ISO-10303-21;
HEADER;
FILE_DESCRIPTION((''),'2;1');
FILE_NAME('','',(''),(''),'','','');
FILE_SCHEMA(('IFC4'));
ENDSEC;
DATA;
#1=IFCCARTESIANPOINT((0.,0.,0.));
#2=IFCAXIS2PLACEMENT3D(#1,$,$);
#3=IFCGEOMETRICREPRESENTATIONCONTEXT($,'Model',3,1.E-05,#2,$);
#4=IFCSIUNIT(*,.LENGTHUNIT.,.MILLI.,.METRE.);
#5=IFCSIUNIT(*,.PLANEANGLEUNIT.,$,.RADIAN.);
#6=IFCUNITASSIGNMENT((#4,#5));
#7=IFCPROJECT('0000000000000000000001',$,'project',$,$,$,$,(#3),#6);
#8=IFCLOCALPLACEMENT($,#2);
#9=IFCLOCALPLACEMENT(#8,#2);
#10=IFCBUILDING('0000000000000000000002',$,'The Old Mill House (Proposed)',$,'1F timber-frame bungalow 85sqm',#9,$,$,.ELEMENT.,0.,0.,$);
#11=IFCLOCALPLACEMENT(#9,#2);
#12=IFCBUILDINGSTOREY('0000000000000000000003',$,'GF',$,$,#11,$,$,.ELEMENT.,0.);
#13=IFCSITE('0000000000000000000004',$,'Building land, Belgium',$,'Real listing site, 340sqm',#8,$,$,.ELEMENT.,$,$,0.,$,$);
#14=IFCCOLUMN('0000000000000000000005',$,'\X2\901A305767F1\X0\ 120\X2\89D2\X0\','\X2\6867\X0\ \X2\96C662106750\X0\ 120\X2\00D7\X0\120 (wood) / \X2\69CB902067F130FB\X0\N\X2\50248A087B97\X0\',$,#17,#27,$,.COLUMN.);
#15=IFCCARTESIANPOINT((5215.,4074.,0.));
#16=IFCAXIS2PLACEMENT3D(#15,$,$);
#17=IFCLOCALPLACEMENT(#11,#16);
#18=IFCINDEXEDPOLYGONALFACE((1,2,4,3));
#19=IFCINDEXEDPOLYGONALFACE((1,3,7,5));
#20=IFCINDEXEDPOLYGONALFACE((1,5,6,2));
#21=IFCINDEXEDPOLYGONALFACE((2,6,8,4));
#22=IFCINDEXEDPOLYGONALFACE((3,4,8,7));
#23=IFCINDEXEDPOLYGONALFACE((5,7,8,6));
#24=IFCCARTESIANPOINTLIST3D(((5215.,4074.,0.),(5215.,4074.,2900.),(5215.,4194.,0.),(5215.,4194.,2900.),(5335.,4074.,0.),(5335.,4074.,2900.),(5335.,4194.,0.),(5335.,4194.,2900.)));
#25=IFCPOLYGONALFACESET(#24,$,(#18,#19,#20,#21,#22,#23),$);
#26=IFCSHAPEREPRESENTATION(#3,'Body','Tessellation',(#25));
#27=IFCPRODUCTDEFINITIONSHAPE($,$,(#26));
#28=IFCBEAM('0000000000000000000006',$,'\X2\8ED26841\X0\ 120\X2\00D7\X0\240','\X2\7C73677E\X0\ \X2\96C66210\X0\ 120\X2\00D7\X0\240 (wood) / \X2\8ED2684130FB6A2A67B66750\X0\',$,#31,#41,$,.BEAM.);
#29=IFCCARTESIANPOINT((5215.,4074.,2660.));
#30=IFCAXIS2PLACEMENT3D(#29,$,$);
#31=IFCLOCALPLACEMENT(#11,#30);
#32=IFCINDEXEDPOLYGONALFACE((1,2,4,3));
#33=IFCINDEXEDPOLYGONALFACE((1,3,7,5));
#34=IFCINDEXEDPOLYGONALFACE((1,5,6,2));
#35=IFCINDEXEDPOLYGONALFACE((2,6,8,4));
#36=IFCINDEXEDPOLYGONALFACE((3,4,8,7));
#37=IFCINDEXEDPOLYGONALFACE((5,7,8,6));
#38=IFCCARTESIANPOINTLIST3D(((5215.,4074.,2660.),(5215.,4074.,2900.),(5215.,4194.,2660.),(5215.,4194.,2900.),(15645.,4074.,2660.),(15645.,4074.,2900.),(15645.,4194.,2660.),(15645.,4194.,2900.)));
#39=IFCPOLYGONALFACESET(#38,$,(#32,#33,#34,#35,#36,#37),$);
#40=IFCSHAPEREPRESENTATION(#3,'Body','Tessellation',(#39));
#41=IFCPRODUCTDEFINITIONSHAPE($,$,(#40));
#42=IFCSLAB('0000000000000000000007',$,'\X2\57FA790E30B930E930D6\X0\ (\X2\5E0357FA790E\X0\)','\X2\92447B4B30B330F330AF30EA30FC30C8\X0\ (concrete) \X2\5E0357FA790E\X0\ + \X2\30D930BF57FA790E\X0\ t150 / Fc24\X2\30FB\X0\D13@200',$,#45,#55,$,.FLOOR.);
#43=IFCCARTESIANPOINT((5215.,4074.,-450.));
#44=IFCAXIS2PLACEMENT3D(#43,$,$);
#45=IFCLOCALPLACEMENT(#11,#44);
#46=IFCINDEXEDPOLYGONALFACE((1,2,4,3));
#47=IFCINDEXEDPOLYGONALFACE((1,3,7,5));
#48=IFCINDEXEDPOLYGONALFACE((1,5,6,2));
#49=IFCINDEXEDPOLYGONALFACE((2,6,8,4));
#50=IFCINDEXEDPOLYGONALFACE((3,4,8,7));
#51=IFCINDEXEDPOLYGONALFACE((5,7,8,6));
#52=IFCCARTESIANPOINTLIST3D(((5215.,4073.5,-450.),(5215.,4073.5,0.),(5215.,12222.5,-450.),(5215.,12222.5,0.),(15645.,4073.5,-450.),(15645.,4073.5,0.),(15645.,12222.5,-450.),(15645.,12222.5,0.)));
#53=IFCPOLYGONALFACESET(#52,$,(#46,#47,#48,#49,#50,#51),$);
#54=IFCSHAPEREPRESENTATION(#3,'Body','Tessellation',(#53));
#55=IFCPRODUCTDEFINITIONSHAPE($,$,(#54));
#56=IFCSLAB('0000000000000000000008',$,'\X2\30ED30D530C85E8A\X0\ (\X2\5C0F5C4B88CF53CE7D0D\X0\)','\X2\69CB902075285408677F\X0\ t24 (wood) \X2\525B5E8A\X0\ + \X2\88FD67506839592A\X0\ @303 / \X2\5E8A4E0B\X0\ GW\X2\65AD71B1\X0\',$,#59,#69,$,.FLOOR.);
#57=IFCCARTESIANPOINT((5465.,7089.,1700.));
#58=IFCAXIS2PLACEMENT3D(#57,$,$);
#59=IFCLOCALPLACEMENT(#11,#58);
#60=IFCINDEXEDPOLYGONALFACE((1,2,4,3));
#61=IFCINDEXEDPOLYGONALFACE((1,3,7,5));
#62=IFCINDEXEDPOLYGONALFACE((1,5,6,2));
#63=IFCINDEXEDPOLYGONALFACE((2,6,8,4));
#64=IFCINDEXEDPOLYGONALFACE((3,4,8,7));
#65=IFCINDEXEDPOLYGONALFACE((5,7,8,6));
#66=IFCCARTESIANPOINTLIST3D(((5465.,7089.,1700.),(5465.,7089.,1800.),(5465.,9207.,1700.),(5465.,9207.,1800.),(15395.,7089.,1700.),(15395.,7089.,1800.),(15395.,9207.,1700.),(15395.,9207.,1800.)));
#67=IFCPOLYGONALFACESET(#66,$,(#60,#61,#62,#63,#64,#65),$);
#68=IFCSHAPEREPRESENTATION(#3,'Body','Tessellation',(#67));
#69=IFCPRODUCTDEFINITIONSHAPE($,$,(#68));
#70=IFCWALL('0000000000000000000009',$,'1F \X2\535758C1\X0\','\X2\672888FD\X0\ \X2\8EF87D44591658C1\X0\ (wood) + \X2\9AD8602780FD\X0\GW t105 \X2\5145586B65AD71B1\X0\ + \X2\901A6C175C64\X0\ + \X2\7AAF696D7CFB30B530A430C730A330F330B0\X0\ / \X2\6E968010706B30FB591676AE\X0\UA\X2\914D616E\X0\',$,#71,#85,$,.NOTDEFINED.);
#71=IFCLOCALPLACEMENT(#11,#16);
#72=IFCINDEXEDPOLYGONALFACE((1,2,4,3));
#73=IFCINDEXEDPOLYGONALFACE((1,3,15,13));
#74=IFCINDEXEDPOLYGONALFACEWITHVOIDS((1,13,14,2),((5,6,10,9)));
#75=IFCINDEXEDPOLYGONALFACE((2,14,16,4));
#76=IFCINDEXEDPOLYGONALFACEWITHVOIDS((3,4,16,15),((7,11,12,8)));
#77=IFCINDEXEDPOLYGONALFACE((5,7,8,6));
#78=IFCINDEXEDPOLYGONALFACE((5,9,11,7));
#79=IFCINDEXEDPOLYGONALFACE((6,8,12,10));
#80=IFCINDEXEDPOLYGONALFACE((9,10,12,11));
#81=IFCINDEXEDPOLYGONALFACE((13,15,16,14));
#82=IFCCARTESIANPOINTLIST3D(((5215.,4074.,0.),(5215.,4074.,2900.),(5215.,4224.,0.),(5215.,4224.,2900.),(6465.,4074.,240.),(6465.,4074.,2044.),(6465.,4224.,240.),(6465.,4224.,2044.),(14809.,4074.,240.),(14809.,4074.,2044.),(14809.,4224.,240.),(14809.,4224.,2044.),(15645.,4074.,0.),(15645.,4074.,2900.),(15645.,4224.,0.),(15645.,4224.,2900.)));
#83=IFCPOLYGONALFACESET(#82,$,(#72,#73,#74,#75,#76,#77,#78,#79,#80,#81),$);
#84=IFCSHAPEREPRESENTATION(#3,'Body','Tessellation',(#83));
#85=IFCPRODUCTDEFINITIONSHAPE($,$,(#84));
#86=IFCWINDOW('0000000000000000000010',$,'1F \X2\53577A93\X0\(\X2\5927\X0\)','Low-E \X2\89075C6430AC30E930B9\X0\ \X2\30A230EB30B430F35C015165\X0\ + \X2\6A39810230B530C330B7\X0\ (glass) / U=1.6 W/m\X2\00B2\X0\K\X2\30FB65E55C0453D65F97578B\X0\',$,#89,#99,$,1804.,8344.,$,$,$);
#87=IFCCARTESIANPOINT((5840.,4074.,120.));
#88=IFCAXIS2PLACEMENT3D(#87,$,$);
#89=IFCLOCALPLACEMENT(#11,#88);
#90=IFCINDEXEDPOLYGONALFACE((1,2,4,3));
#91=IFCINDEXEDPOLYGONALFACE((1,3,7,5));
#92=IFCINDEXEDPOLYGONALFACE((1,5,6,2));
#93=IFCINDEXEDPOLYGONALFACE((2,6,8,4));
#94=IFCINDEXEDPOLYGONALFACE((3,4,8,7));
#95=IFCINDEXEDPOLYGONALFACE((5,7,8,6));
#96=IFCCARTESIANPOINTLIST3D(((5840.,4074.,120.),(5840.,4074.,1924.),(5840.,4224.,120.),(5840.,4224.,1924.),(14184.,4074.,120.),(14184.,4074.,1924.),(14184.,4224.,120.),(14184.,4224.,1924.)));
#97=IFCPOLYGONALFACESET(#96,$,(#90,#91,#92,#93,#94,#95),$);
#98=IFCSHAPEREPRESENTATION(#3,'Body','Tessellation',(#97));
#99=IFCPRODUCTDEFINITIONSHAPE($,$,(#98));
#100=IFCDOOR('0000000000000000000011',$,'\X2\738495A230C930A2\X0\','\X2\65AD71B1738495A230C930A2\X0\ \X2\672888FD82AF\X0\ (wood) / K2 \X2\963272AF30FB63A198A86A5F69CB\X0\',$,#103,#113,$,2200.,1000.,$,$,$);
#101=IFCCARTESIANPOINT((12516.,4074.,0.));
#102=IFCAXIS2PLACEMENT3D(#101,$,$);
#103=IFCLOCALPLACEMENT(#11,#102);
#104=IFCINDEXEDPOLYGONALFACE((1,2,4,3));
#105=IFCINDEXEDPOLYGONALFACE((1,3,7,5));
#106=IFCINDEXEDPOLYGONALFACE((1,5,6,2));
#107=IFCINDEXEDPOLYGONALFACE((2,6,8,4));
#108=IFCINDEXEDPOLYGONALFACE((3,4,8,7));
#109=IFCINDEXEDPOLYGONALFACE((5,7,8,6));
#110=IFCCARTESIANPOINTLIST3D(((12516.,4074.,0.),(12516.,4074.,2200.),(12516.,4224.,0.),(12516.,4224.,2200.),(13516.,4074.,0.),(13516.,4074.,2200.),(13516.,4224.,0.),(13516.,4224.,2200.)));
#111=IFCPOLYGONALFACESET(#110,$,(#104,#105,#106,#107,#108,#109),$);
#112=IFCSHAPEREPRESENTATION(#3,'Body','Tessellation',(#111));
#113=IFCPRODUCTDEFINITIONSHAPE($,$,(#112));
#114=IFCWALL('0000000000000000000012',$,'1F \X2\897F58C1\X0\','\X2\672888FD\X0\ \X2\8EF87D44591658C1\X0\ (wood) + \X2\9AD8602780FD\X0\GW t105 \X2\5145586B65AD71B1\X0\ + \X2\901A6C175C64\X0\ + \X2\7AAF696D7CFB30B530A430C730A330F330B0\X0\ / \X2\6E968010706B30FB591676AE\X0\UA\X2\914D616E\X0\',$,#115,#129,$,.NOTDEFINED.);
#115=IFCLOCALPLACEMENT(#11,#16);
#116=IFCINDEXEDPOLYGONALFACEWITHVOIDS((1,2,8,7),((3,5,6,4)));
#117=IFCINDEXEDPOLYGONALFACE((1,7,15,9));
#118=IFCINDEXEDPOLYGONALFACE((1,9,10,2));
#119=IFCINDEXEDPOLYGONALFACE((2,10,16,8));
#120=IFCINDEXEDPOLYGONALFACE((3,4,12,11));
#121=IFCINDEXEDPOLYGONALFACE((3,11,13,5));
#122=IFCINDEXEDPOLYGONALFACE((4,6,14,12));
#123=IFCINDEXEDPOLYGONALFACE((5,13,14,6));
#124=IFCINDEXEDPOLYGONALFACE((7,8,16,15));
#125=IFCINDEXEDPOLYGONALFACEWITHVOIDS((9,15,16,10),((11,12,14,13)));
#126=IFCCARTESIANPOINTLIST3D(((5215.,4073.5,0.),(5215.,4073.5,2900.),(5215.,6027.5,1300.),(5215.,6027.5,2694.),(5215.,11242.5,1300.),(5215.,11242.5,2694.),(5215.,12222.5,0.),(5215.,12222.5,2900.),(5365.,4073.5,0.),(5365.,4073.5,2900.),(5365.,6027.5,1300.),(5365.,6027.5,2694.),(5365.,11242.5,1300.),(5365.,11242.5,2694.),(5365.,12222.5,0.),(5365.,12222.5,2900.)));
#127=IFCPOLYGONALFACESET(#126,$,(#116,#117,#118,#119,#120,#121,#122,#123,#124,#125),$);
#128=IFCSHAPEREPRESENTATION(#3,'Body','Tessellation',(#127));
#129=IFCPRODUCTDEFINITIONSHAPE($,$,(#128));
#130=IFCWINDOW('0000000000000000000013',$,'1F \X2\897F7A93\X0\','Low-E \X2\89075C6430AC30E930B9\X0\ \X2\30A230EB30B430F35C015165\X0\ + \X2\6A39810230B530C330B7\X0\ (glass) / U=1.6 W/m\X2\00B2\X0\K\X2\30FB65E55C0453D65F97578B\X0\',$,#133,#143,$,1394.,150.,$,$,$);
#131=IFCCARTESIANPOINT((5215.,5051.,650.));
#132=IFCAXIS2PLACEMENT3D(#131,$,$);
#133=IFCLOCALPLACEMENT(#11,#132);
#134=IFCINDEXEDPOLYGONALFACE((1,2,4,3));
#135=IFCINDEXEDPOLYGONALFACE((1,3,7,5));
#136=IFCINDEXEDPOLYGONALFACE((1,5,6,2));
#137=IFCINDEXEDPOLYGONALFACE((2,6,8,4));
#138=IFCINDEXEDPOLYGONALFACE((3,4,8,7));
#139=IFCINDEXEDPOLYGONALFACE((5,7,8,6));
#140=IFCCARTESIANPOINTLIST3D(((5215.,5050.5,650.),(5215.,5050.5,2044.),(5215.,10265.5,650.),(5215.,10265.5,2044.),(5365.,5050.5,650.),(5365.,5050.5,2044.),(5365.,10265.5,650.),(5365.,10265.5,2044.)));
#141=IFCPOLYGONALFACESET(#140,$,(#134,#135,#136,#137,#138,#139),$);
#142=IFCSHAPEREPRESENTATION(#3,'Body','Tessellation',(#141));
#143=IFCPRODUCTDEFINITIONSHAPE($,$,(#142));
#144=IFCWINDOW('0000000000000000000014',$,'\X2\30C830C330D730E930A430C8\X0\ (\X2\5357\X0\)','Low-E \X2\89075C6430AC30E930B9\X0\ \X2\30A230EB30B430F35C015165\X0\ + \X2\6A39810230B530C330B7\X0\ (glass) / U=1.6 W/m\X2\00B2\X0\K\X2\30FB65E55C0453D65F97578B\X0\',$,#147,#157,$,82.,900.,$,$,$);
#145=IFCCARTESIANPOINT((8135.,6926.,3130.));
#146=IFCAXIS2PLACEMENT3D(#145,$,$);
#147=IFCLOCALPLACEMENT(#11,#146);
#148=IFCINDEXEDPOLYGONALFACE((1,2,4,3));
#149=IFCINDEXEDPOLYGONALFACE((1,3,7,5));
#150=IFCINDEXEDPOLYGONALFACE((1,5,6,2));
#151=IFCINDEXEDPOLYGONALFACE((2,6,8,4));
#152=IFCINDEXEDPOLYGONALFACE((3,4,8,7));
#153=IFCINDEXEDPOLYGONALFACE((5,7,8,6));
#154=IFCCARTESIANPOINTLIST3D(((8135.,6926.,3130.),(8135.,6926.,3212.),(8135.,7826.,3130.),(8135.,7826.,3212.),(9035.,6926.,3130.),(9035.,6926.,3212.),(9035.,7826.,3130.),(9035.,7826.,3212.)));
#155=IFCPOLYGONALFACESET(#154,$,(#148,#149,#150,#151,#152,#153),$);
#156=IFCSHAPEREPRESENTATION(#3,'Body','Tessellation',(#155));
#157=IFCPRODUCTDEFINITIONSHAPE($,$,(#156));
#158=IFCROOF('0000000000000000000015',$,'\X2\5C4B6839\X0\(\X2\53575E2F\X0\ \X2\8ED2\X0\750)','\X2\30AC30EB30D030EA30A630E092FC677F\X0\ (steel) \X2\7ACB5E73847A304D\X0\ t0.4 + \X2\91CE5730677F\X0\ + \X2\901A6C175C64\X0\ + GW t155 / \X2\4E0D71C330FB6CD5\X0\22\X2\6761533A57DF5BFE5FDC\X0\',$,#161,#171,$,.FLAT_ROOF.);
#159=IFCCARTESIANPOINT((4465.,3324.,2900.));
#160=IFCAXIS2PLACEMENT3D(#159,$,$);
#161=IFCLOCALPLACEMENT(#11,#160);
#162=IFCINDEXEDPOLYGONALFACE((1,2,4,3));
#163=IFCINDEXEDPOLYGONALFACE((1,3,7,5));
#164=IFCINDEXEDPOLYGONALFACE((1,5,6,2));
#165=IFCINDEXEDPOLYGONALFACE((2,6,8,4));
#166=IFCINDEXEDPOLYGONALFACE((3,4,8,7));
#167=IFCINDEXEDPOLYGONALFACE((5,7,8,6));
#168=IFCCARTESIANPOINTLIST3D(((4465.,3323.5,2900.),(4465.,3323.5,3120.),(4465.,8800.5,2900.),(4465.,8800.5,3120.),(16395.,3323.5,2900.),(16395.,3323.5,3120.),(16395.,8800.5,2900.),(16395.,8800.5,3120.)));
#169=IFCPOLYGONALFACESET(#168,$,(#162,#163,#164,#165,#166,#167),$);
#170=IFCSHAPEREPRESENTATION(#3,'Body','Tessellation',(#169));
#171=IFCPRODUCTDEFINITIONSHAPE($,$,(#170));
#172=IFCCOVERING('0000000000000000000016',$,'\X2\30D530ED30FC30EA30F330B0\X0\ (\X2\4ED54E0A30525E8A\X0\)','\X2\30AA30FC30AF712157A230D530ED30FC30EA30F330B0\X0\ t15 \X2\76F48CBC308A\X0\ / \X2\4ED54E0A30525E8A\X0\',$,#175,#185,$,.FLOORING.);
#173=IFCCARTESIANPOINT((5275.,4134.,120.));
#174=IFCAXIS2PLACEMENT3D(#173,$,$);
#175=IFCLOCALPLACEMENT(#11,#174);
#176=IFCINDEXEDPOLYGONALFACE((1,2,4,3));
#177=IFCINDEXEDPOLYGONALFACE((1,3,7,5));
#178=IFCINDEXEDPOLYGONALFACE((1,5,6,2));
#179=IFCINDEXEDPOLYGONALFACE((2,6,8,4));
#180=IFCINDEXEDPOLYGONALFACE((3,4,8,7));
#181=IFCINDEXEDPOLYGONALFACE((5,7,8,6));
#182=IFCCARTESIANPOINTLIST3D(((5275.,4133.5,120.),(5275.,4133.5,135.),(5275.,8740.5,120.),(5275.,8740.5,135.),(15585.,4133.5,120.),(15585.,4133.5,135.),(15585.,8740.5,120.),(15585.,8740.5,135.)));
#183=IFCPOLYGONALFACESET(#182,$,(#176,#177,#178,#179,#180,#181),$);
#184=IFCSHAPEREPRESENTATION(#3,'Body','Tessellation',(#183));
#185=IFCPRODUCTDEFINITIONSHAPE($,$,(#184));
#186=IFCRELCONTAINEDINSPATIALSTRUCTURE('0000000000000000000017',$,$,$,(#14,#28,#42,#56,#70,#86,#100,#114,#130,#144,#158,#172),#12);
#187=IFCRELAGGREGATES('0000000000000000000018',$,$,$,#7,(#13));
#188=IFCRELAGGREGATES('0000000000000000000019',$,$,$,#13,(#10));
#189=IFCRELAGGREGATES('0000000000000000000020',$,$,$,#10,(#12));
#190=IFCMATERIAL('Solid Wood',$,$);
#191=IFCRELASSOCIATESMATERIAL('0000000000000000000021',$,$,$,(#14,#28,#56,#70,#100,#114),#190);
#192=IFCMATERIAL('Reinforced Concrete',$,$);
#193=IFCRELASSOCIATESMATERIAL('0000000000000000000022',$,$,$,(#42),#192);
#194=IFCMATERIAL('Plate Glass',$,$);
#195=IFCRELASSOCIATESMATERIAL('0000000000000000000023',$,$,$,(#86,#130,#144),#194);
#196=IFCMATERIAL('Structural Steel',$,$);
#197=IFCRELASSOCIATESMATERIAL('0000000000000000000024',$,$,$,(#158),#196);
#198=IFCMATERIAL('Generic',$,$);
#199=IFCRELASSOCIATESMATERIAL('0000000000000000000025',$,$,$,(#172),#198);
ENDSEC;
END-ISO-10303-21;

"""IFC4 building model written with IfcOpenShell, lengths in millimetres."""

from ifc_helpers import new_model, si_unit, frame, frame_2d, origin, place, context, project, spatial, rectangle, extrude, material, element, fill, save


model = new_model("IFC4")

# Units and contexts
model_context = context("Model", 3, precision=1e-05, world=origin())
ifc_project = project(units=[si_unit("LENGTHUNIT", "METRE", prefix="MILLI"), si_unit("PLANEANGLEUNIT", "RADIAN")], contexts=[model_context])

# Site, building, storey
site_placement = place(None, origin())
site = spatial("IfcSite", under=ifc_project, at=site_placement, Name="Building land, Belgium", ObjectType="Real listing site, 340sqm", CompositionType="ELEMENT", RefElevation=0.0)
building_placement = place(site_placement, origin())
building = spatial("IfcBuilding", under=site, at=building_placement, Name="The Old Mill House (Proposed)", ObjectType="1F timber-frame bungalow 85sqm", CompositionType="ELEMENT", ElevationOfRefHeight=0.0, ElevationOfTerrain=0.0)
storey_placement = place(building_placement, origin())
storey = spatial("IfcBuildingStorey", under=building, at=storey_placement, Name="GF", CompositionType="ELEMENT", Elevation=0.0)

# Column
ifc_material_1 = material(Name="Solid Wood")
column_1_placement = place(storey_placement, frame((5215.0, 4074.0, 0.0)))
element("IfcColumn", 1, at=column_1_placement, inside=storey, material=ifc_material_1, Name="通し柱 120角", Description="桧 集成材 120×120 (wood) / 構造柱・N値計算", PredefinedType="COLUMN", context=model_context, shape_type="SweptSolid", body=[
    extrude(rectangle(XDim=120.0, YDim=120.0, at=frame_2d((60.0, 60.0))), frame((5215.0, 4074.0, 0.0)), (0.0, 0.0, 1.0), 2900.0),
])

# Beam
beam_1_placement = place(storey_placement, frame((5215.0, 4074.0, 2660.0)))
element("IfcBeam", 2, at=beam_1_placement, inside=storey, material=ifc_material_1, Name="軒桁 120×240", Description="米松 集成 120×240 (wood) / 軒桁・横架材", PredefinedType="BEAM", context=model_context, shape_type="SweptSolid", body=[
    extrude(rectangle(XDim=10430.0, YDim=120.0, at=frame_2d((5215.0, 60.0))), frame((5215.0, 4074.0, 2660.0)), (0.0, 0.0, 1.0), 240.0),
])

# Slabs
ifc_material_2 = material(Name="Reinforced Concrete")
slab_1_placement = place(storey_placement, frame((5215.0, 4074.0, -450.0)))
element("IfcSlab", 3, at=slab_1_placement, inside=storey, material=ifc_material_2, Name="基礎スラブ (布基礎)", Description="鉄筋コンクリート (concrete) 布基礎 + ベタ基礎 t150 / Fc24・D13@200", PredefinedType="FLOOR", context=model_context, shape_type="SweptSolid", body=[
    extrude(rectangle(XDim=10430.0, YDim=8149.0, at=frame_2d((5215.0, 4074.0))), frame((5215.0, 4074.0, -450.0)), (0.0, 0.0, 1.0), 450.0),
])
slab_2_placement = place(storey_placement, frame((5465.0, 7089.0, 1700.0)))
element("IfcSlab", 4, at=slab_2_placement, inside=storey, material=ifc_material_1, Name="ロフト床 (小屋裏収納)", Description="構造用合板 t24 (wood) 剛床 + 製材根太 @303 / 床下 GW断熱", PredefinedType="FLOOR", context=model_context, shape_type="SweptSolid", body=[
    extrude(rectangle(XDim=9930.0, YDim=2118.0, at=frame_2d((4965.0, 1059.0))), frame((5465.0, 7089.0, 1700.0)), (0.0, 0.0, 1.0), 100.0),
])

# Wall, openings, window, door
wall_1_placement = place(storey_placement, frame((5215.0, 4074.0, 0.0)))
wall_1 = element("IfcWall", 5, at=wall_1_placement, inside=storey, material=ifc_material_1, Name="1F 南壁", Description="木製 軸組外壁 (wood) + 高性能GW t105 充填断熱 + 通気層 + 窯業系サイディング / 準耐火・外皮UA配慮", PredefinedType="NOTDEFINED", context=model_context, shape_type="SweptSolid", body=[
    extrude(rectangle(XDim=10430.0, YDim=150.0, at=frame_2d((5215.0, 75.0))), frame((5215.0, 4074.0, 0.0)), (0.0, 0.0, 1.0), 2900.0),
])
opening_1_placement = place(storey_placement, frame((5840.0, 4074.0, 120.0)))
opening_1 = element("IfcOpeningElement", 6, at=opening_1_placement, cuts=wall_1, PredefinedType="NOTDEFINED", context=model_context, shape_type="SweptSolid", body=[
    extrude(rectangle(XDim=8344.0, YDim=150.0, at=frame_2d((4172.0, 75.0))), frame((5840.0, 4074.0, 120.0)), (0.0, 0.0, 1.0), 1804.0),
])
opening_2_placement = place(storey_placement, frame((12516.0, 4074.0, 0.0)))
opening_2 = element("IfcOpeningElement", 7, at=opening_2_placement, cuts=wall_1, PredefinedType="NOTDEFINED", context=model_context, shape_type="SweptSolid", body=[
    extrude(rectangle(XDim=1000.0, YDim=150.0, at=frame_2d((500.0, 75.0))), frame((12516.0, 4074.0, 0.0)), (0.0, 0.0, 1.0), 2200.0),
])
ifc_material_3 = material(Name="Plate Glass")
window_1_placement = place(storey_placement, frame((5840.0, 4074.0, 120.0)))
window_1 = element("IfcWindow", 8, at=window_1_placement, inside=storey, material=ifc_material_3, Name="1F 南窓(大)", Description="Low-E 複層ガラス アルゴン封入 + 樹脂サッシ (glass) / U=1.6 W/m²K・日射取得型", OverallHeight=1804.0, OverallWidth=8344.0, context=model_context, shape_type="SweptSolid", body=[
    extrude(rectangle(XDim=8344.0, YDim=150.0, at=frame_2d((4172.0, 75.0))), frame((5840.0, 4074.0, 120.0)), (0.0, 0.0, 1.0), 1804.0),
])
fill(opening_1, window_1)
door_placement = place(storey_placement, frame((12516.0, 4074.0, 0.0)))
door = element("IfcDoor", 9, at=door_placement, inside=storey, material=ifc_material_1, Name="玄関ドア", Description="断熱玄関ドア 木製芯 (wood) / K2 防犯・採風機構", OverallHeight=2200.0, OverallWidth=1000.0, context=model_context, shape_type="SweptSolid", body=[
    extrude(rectangle(XDim=1000.0, YDim=150.0, at=frame_2d((500.0, 75.0))), frame((12516.0, 4074.0, 0.0)), (0.0, 0.0, 1.0), 2200.0),
])
fill(opening_2, door)

# Wall, opening, window
wall_2_placement = place(storey_placement, frame((5215.0, 4074.0, 0.0)))
wall_2 = element("IfcWall", 10, at=wall_2_placement, inside=storey, material=ifc_material_1, Name="1F 西壁", Description="木製 軸組外壁 (wood) + 高性能GW t105 充填断熱 + 通気層 + 窯業系サイディング / 準耐火・外皮UA配慮", PredefinedType="NOTDEFINED", context=model_context, shape_type="SweptSolid", body=[
    extrude(rectangle(XDim=150.0, YDim=8149.0, at=frame_2d((75.0, 4074.0))), frame((5215.0, 4074.0, 0.0)), (0.0, 0.0, 1.0), 2900.0),
])
opening_3_placement = place(storey_placement, frame((5215.0, 5051.0, 650.0)))
opening_3 = element("IfcOpeningElement", 11, at=opening_3_placement, cuts=wall_2, PredefinedType="NOTDEFINED", context=model_context, shape_type="SweptSolid", body=[
    extrude(rectangle(XDim=150.0, YDim=5215.0, at=frame_2d((75.0, 2607.0))), frame((5215.0, 5051.0, 650.0)), (0.0, 0.0, 1.0), 1394.0),
])
window_2_placement = place(storey_placement, frame((5215.0, 5051.0, 650.0)))
window_2 = element("IfcWindow", 12, at=window_2_placement, inside=storey, material=ifc_material_3, Name="1F 西窓", Description="Low-E 複層ガラス アルゴン封入 + 樹脂サッシ (glass) / U=1.6 W/m²K・日射取得型", OverallHeight=1394.0, OverallWidth=150.0, context=model_context, shape_type="SweptSolid", body=[
    extrude(rectangle(XDim=150.0, YDim=5215.0, at=frame_2d((75.0, 2607.0))), frame((5215.0, 5051.0, 650.0)), (0.0, 0.0, 1.0), 1394.0),
])
fill(opening_3, window_2)

# Window
window_3_placement = place(storey_placement, frame((8135.0, 6926.0, 3130.0)))
element("IfcWindow", 13, at=window_3_placement, inside=storey, material=ifc_material_3, Name="トップライト (南)", Description="Low-E 複層ガラス アルゴン封入 + 樹脂サッシ (glass) / U=1.6 W/m²K・日射取得型", OverallHeight=82.0, OverallWidth=900.0, context=model_context, shape_type="SweptSolid", body=[
    extrude(rectangle(XDim=900.0, YDim=900.0, at=frame_2d((450.0, 450.0))), frame((8135.0, 6926.0, 3130.0)), (0.0, 0.0, 1.0), 82.0),
])

# Roof
ifc_material_4 = material(Name="Structural Steel")
roof_placement = place(storey_placement, frame((4465.0, 3324.0, 2900.0)))
element("IfcRoof", 14, at=roof_placement, inside=storey, material=ifc_material_4, Name="屋根(南帯 軒750)", Description="ガルバリウム鋼板 (steel) 立平葺き t0.4 + 野地板 + 通気層 + GW t155 / 不燃・法22条区域対応", PredefinedType="FLAT_ROOF", context=model_context, shape_type="SweptSolid", body=[
    extrude(rectangle(XDim=11930.0, YDim=5477.0, at=frame_2d((5965.0, 2738.0))), frame((4465.0, 3324.0, 2900.0)), (0.0, 0.0, 1.0), 220.0),
])

# Covering
ifc_material_5 = material(Name="Generic")
covering_1_placement = place(storey_placement, frame((5275.0, 4134.0, 120.0)))
element("IfcCovering", 15, at=covering_1_placement, inside=storey, material=ifc_material_5, Name="フローリング (仕上げ床)", Description="オーク無垢フローリング t15 直貼り / 仕上げ床", PredefinedType="FLOORING", context=model_context, shape_type="SweptSolid", body=[
    extrude(rectangle(XDim=10310.0, YDim=4607.0, at=frame_2d((5155.0, 2303.0))), frame((5275.0, 4134.0, 120.0)), (0.0, 0.0, 1.0), 15.0),
])

save(model, "model.ifc")
